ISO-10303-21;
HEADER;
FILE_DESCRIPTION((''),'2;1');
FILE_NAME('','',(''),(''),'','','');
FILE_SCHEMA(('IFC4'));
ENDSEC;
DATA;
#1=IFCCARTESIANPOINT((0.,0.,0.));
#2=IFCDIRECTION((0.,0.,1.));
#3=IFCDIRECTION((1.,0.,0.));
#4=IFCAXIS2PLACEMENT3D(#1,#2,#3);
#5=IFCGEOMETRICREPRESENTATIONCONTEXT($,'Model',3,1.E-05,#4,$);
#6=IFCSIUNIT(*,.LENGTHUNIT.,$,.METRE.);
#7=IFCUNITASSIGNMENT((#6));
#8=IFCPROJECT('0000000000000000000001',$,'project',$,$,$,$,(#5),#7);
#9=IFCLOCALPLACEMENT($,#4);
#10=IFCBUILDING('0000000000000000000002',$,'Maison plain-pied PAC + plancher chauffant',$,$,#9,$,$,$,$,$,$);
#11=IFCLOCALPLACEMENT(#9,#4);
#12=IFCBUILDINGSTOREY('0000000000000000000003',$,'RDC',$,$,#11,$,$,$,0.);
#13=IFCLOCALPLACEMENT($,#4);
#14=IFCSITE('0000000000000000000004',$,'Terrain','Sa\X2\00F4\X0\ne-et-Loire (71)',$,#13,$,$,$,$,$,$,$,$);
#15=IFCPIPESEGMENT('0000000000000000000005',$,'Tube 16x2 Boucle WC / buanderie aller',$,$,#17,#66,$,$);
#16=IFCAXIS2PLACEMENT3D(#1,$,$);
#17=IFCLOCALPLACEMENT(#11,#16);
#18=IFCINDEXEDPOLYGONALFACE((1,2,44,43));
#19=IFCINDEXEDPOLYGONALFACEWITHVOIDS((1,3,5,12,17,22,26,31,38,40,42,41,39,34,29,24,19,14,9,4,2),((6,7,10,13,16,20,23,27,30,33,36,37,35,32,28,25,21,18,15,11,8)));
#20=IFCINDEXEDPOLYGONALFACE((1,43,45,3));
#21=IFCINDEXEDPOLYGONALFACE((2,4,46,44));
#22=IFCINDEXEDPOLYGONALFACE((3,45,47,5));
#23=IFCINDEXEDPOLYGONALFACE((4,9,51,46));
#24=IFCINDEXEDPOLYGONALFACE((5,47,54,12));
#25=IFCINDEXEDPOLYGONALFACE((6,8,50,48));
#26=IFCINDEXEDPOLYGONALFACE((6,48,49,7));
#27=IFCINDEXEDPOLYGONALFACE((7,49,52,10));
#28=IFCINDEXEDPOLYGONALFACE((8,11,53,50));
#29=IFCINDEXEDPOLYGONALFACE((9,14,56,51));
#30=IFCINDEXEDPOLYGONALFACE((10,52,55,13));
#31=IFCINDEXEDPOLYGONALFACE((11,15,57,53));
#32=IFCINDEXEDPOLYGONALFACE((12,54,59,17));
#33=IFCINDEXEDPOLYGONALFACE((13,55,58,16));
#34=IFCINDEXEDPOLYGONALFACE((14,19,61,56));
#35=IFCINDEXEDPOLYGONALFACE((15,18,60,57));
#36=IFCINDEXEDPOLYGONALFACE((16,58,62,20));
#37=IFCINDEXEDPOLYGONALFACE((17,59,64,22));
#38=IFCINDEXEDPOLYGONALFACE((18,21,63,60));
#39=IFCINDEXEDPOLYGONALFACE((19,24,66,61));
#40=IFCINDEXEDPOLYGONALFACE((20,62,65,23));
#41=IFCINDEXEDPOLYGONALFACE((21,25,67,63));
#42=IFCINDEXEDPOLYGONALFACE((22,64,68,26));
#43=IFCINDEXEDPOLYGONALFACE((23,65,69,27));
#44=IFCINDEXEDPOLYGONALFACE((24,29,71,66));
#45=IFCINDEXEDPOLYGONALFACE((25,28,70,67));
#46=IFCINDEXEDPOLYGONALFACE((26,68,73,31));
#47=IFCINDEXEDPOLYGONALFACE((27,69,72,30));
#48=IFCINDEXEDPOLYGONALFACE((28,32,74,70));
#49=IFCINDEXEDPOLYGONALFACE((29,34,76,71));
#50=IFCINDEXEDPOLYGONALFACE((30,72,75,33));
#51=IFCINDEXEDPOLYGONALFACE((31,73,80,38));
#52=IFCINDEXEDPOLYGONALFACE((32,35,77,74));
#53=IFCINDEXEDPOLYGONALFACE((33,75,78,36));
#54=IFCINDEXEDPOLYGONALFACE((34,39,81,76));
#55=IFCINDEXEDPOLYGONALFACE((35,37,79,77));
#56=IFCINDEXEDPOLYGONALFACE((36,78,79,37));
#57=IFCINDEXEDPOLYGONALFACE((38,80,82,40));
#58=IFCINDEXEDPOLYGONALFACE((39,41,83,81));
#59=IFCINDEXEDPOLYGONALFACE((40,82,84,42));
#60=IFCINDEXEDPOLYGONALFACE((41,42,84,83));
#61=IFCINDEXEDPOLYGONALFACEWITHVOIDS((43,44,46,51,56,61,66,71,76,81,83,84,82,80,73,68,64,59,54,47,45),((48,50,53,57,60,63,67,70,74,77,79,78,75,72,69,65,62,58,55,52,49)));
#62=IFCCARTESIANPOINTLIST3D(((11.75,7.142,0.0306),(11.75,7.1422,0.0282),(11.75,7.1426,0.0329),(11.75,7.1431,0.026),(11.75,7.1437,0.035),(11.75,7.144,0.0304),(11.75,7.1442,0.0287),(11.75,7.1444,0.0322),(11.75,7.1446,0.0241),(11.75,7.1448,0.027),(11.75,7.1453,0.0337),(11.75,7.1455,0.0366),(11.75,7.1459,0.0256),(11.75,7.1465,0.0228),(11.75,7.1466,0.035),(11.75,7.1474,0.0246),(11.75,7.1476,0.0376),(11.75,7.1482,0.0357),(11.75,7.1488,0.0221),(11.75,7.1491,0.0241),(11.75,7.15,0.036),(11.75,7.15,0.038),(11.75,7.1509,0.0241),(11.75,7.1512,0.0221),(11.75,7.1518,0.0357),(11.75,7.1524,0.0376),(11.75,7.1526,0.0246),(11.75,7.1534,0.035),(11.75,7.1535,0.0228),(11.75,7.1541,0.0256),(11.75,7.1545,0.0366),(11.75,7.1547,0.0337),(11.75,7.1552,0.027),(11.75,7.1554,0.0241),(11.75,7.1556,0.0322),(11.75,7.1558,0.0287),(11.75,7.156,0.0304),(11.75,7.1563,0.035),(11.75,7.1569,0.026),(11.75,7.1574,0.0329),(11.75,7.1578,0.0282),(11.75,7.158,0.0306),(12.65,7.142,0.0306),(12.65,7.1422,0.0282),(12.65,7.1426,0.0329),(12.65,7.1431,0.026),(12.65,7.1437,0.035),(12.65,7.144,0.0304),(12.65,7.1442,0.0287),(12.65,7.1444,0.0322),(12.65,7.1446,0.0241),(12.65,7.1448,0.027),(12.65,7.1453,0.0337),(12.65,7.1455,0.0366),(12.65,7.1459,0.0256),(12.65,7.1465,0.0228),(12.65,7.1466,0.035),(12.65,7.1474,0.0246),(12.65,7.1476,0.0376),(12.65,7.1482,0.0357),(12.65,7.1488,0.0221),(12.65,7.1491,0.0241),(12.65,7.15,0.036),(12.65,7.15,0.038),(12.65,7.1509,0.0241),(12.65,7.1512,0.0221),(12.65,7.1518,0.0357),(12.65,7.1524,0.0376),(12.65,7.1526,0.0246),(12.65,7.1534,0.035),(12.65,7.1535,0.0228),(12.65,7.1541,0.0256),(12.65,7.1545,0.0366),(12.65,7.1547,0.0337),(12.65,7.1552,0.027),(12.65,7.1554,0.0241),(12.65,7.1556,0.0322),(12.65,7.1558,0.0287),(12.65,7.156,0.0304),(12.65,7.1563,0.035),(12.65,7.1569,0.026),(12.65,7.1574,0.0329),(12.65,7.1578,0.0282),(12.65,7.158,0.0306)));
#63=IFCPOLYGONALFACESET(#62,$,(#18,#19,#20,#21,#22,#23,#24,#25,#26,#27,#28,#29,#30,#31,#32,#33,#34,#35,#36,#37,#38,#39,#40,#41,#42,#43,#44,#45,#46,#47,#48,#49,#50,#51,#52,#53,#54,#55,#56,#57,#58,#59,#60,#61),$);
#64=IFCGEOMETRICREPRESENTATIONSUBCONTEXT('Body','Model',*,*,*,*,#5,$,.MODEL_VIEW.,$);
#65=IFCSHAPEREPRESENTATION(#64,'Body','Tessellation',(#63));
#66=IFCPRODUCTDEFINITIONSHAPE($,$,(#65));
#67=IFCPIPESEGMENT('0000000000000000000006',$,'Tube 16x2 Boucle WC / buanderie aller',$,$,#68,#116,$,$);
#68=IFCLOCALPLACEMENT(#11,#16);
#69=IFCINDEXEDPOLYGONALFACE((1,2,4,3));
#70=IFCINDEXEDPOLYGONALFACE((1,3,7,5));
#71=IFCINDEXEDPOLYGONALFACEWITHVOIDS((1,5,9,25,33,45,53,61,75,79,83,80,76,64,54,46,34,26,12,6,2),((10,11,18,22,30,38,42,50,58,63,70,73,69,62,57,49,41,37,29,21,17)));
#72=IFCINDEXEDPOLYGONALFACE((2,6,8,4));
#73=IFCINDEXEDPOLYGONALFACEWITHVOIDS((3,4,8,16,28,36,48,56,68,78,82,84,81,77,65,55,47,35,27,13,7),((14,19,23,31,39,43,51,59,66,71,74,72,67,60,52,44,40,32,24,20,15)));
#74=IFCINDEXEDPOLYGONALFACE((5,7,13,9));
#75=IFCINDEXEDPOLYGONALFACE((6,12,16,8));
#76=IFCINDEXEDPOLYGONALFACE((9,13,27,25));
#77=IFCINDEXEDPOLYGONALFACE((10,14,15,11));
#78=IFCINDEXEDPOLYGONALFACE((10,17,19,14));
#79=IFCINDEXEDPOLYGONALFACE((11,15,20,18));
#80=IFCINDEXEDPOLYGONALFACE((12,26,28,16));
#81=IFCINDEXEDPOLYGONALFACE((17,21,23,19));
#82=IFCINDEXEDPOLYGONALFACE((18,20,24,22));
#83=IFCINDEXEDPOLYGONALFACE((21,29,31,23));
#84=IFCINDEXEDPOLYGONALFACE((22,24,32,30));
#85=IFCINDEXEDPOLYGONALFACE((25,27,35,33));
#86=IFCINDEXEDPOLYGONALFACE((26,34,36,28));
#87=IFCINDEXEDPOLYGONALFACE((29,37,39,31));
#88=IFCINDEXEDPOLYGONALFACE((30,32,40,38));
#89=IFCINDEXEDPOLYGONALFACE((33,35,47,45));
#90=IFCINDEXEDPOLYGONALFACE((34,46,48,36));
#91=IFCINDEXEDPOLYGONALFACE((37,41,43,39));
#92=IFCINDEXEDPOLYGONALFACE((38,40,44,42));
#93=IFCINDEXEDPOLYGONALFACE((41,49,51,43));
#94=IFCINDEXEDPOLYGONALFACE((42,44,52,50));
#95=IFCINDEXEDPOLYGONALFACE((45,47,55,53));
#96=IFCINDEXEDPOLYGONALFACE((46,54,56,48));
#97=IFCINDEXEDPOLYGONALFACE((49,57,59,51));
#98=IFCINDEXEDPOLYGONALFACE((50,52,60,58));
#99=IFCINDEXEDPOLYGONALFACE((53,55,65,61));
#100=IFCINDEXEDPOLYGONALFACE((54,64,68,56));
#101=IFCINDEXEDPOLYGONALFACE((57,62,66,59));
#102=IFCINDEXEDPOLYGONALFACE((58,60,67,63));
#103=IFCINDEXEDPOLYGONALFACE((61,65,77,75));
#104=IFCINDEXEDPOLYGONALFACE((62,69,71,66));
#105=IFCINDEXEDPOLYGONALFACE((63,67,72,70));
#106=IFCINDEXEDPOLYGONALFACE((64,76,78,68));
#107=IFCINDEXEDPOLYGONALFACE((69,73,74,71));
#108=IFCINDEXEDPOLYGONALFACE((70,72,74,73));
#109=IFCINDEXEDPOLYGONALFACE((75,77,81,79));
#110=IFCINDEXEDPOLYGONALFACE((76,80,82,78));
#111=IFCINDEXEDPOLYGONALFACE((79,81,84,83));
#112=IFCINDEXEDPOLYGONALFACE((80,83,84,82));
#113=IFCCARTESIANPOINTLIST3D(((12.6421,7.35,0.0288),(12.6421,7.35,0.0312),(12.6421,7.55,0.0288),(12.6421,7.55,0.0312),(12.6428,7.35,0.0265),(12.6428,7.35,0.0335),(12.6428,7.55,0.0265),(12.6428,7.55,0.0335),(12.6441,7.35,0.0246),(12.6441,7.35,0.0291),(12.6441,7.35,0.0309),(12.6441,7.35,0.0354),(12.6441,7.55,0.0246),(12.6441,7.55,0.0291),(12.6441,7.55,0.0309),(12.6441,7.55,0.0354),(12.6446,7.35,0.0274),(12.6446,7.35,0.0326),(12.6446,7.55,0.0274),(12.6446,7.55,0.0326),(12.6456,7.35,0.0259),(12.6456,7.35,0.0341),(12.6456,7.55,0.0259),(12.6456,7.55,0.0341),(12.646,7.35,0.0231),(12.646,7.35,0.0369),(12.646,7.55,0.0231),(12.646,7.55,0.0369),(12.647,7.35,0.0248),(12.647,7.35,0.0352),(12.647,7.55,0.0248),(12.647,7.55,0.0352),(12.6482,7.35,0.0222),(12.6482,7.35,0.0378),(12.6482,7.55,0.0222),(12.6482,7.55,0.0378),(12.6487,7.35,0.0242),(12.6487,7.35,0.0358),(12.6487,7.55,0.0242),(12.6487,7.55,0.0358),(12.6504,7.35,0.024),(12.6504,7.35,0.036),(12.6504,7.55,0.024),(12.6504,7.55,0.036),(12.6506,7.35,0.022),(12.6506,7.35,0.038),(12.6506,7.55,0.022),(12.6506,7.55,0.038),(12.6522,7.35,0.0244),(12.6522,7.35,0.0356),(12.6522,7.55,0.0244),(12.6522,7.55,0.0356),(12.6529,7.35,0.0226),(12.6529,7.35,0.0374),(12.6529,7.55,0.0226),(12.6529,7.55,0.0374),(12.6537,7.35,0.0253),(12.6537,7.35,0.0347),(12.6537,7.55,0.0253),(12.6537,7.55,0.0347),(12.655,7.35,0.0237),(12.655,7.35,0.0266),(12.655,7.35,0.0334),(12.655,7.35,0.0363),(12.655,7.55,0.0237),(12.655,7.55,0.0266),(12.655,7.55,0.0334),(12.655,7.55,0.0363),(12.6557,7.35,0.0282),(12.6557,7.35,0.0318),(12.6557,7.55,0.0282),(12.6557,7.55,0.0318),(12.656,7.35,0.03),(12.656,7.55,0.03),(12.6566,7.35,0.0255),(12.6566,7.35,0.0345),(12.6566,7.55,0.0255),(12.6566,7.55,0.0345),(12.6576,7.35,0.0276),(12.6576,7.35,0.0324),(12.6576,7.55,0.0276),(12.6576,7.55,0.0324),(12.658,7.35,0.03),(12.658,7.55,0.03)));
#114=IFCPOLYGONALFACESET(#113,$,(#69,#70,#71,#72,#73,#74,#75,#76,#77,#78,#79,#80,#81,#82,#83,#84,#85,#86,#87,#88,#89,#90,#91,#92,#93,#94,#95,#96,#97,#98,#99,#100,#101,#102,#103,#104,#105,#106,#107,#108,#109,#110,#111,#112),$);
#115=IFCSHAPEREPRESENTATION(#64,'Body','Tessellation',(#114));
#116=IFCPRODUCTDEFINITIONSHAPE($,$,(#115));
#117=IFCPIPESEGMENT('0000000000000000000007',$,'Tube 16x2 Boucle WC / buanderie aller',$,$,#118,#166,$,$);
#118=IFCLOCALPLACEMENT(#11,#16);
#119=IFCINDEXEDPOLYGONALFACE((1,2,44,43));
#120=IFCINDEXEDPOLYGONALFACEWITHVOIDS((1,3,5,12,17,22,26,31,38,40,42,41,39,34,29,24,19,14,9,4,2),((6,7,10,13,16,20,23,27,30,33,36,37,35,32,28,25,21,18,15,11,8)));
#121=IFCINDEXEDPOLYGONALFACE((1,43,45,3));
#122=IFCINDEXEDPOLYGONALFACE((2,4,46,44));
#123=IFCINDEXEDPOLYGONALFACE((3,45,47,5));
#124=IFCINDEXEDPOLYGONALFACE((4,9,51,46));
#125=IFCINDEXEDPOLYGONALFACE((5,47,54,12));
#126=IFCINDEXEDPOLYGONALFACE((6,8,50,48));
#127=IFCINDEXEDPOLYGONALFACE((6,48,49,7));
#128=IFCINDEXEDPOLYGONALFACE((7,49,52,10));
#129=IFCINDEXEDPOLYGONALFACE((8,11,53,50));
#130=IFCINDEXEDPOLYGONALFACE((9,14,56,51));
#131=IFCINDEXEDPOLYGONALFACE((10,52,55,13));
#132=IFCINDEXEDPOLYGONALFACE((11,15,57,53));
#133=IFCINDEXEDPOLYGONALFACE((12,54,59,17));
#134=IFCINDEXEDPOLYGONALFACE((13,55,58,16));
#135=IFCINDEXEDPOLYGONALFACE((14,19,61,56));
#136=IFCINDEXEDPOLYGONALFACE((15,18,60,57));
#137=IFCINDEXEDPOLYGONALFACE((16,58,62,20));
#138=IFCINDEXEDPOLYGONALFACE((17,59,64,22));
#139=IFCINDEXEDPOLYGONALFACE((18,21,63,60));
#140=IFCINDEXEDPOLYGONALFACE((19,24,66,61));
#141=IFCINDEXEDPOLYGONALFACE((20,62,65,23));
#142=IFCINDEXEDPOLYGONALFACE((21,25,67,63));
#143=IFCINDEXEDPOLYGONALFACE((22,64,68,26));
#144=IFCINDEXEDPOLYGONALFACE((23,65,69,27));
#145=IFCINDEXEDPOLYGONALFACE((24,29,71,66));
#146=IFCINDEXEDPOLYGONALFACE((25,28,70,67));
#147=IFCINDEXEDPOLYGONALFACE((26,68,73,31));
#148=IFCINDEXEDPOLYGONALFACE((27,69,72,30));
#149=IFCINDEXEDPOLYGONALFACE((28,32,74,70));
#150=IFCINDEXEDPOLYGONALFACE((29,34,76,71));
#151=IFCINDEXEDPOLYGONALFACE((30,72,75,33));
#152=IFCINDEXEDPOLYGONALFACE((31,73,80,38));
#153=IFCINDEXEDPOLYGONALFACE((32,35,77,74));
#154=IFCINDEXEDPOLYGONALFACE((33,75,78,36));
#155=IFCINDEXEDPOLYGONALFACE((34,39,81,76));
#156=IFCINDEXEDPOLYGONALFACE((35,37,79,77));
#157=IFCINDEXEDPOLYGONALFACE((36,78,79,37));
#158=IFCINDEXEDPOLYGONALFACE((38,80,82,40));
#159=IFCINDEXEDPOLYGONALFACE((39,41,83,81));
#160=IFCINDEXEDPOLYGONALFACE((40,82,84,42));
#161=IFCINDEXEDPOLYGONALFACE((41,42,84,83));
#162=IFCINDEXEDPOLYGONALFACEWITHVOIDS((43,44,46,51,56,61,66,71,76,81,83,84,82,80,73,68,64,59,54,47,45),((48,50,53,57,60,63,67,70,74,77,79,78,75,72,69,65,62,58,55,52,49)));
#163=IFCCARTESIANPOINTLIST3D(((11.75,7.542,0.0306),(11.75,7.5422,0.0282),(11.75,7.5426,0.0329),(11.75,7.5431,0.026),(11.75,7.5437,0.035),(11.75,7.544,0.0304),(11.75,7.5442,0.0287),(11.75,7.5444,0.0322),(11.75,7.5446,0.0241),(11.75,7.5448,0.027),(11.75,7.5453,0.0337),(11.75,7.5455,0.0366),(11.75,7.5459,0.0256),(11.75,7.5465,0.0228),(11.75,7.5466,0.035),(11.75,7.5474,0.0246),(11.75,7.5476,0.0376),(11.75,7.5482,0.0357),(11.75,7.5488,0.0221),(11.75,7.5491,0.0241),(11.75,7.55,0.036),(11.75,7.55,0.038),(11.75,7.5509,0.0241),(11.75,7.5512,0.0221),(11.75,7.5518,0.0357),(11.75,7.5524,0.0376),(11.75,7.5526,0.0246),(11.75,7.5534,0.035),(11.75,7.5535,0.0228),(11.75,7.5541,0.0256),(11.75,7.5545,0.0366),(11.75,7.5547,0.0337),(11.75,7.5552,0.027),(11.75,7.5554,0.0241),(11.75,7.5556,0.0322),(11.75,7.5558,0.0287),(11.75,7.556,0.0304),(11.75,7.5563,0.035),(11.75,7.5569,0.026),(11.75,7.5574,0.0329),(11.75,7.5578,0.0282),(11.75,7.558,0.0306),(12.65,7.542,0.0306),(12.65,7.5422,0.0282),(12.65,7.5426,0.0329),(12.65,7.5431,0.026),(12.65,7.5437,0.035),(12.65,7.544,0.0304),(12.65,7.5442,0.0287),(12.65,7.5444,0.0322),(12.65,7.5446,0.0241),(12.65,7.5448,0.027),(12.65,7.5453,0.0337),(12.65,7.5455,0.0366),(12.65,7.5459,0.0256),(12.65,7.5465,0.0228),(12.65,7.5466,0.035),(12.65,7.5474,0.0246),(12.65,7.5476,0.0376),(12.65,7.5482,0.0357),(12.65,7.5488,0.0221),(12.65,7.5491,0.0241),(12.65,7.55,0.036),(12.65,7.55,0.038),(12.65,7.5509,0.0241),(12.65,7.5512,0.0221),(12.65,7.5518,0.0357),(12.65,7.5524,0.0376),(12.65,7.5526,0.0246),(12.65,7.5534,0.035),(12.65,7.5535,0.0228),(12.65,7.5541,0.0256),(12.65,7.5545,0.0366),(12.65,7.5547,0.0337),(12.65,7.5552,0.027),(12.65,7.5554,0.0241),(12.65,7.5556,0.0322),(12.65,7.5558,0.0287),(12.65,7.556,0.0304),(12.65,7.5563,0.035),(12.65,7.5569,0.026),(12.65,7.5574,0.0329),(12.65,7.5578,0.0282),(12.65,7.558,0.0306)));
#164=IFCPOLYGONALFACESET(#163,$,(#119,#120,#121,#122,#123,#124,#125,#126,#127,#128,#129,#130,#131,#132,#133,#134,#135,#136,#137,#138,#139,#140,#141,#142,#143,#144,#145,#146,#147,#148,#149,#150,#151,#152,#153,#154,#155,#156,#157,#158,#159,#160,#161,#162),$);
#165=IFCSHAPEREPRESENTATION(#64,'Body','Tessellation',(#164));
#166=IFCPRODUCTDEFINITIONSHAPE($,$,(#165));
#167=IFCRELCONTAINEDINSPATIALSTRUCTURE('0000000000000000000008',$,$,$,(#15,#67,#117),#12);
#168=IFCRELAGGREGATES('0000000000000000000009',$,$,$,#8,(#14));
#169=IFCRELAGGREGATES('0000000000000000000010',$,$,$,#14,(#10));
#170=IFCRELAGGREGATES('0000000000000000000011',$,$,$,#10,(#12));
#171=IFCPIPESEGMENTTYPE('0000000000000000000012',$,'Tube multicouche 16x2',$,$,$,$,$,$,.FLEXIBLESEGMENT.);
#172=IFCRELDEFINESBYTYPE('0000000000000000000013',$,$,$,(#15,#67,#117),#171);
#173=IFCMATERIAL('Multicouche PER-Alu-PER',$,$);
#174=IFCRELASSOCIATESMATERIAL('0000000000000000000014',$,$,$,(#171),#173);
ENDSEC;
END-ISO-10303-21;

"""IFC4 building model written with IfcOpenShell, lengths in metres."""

from ifc_helpers import new_model, si_unit, frame, origin_with_axes, place, context, subcontext, project, spatial, hollow_circle, extrude, material, type_object, element, save


model = new_model("IFC4")

# Units and contexts
model_context = context("Model", 3, precision=1e-05, world=origin_with_axes())
body_context = subcontext(model_context, "Body", "Model", "MODEL_VIEW")
ifc_project = project(units=[si_unit("LENGTHUNIT", "METRE")], contexts=[model_context])

# Site, building, storey
site_placement = place(None, origin_with_axes())
site = spatial("IfcSite", under=ifc_project, at=site_placement, Name="Terrain", Description="Saône-et-Loire (71)")
building_placement = place(None, origin_with_axes())
building = spatial("IfcBuilding", under=site, at=building_placement, Name="Maison plain-pied PAC + plancher chauffant")
storey_placement = place(building_placement, origin_with_axes())
storey = spatial("IfcBuildingStorey", under=building, at=storey_placement, Name="RDC", Elevation=0.0)

# Pipe segments
ifc_material_1 = material(Name="Multicouche PER-Alu-PER")
pipe_segment_type_1 = type_object("IfcPipeSegmentType", Name="Tube multicouche 16x2", PredefinedType="FLEXIBLESEGMENT", material=ifc_material_1)
pipe_segment_1_placement = place(storey_placement, frame((12.65, 7.15, 0.03), z_axis=(-1.0, 0.0, 0.0), x_axis=(0.0, 0.0, 1.0)))
element("IfcPipeSegment", 1, at=pipe_segment_1_placement, inside=storey, type_object=pipe_segment_type_1, Name="Tube 16x2 Boucle WC / buanderie aller", context=body_context, shape_type="SweptSolid", body=[
    extrude(hollow_circle(Radius=0.008, WallThickness=0.002), origin_with_axes(), (0.0, 0.0, 1.0), 0.9),
])
pipe_segment_2_placement = place(storey_placement, frame((12.65, 7.35, 0.03), z_axis=(0.0, 1.0, 0.0), x_axis=(1.0, 0.0, 0.0)))
element("IfcPipeSegment", 2, at=pipe_segment_2_placement, inside=storey, type_object=pipe_segment_type_1, Name="Tube 16x2 Boucle WC / buanderie aller", context=body_context, shape_type="SweptSolid", body=[
    extrude(hollow_circle(Radius=0.008, WallThickness=0.002), origin_with_axes(), (0.0, 0.0, 1.0), 0.2),
])
pipe_segment_3_placement = place(storey_placement, frame((12.65, 7.55, 0.03), z_axis=(-1.0, 0.0, 0.0), x_axis=(0.0, 0.0, 1.0)))
element("IfcPipeSegment", 3, at=pipe_segment_3_placement, inside=storey, type_object=pipe_segment_type_1, Name="Tube 16x2 Boucle WC / buanderie aller", context=body_context, shape_type="SweptSolid", body=[
    extrude(hollow_circle(Radius=0.008, WallThickness=0.002), origin_with_axes(), (0.0, 0.0, 1.0), 0.9),
])

save(model, "model.ifc")
